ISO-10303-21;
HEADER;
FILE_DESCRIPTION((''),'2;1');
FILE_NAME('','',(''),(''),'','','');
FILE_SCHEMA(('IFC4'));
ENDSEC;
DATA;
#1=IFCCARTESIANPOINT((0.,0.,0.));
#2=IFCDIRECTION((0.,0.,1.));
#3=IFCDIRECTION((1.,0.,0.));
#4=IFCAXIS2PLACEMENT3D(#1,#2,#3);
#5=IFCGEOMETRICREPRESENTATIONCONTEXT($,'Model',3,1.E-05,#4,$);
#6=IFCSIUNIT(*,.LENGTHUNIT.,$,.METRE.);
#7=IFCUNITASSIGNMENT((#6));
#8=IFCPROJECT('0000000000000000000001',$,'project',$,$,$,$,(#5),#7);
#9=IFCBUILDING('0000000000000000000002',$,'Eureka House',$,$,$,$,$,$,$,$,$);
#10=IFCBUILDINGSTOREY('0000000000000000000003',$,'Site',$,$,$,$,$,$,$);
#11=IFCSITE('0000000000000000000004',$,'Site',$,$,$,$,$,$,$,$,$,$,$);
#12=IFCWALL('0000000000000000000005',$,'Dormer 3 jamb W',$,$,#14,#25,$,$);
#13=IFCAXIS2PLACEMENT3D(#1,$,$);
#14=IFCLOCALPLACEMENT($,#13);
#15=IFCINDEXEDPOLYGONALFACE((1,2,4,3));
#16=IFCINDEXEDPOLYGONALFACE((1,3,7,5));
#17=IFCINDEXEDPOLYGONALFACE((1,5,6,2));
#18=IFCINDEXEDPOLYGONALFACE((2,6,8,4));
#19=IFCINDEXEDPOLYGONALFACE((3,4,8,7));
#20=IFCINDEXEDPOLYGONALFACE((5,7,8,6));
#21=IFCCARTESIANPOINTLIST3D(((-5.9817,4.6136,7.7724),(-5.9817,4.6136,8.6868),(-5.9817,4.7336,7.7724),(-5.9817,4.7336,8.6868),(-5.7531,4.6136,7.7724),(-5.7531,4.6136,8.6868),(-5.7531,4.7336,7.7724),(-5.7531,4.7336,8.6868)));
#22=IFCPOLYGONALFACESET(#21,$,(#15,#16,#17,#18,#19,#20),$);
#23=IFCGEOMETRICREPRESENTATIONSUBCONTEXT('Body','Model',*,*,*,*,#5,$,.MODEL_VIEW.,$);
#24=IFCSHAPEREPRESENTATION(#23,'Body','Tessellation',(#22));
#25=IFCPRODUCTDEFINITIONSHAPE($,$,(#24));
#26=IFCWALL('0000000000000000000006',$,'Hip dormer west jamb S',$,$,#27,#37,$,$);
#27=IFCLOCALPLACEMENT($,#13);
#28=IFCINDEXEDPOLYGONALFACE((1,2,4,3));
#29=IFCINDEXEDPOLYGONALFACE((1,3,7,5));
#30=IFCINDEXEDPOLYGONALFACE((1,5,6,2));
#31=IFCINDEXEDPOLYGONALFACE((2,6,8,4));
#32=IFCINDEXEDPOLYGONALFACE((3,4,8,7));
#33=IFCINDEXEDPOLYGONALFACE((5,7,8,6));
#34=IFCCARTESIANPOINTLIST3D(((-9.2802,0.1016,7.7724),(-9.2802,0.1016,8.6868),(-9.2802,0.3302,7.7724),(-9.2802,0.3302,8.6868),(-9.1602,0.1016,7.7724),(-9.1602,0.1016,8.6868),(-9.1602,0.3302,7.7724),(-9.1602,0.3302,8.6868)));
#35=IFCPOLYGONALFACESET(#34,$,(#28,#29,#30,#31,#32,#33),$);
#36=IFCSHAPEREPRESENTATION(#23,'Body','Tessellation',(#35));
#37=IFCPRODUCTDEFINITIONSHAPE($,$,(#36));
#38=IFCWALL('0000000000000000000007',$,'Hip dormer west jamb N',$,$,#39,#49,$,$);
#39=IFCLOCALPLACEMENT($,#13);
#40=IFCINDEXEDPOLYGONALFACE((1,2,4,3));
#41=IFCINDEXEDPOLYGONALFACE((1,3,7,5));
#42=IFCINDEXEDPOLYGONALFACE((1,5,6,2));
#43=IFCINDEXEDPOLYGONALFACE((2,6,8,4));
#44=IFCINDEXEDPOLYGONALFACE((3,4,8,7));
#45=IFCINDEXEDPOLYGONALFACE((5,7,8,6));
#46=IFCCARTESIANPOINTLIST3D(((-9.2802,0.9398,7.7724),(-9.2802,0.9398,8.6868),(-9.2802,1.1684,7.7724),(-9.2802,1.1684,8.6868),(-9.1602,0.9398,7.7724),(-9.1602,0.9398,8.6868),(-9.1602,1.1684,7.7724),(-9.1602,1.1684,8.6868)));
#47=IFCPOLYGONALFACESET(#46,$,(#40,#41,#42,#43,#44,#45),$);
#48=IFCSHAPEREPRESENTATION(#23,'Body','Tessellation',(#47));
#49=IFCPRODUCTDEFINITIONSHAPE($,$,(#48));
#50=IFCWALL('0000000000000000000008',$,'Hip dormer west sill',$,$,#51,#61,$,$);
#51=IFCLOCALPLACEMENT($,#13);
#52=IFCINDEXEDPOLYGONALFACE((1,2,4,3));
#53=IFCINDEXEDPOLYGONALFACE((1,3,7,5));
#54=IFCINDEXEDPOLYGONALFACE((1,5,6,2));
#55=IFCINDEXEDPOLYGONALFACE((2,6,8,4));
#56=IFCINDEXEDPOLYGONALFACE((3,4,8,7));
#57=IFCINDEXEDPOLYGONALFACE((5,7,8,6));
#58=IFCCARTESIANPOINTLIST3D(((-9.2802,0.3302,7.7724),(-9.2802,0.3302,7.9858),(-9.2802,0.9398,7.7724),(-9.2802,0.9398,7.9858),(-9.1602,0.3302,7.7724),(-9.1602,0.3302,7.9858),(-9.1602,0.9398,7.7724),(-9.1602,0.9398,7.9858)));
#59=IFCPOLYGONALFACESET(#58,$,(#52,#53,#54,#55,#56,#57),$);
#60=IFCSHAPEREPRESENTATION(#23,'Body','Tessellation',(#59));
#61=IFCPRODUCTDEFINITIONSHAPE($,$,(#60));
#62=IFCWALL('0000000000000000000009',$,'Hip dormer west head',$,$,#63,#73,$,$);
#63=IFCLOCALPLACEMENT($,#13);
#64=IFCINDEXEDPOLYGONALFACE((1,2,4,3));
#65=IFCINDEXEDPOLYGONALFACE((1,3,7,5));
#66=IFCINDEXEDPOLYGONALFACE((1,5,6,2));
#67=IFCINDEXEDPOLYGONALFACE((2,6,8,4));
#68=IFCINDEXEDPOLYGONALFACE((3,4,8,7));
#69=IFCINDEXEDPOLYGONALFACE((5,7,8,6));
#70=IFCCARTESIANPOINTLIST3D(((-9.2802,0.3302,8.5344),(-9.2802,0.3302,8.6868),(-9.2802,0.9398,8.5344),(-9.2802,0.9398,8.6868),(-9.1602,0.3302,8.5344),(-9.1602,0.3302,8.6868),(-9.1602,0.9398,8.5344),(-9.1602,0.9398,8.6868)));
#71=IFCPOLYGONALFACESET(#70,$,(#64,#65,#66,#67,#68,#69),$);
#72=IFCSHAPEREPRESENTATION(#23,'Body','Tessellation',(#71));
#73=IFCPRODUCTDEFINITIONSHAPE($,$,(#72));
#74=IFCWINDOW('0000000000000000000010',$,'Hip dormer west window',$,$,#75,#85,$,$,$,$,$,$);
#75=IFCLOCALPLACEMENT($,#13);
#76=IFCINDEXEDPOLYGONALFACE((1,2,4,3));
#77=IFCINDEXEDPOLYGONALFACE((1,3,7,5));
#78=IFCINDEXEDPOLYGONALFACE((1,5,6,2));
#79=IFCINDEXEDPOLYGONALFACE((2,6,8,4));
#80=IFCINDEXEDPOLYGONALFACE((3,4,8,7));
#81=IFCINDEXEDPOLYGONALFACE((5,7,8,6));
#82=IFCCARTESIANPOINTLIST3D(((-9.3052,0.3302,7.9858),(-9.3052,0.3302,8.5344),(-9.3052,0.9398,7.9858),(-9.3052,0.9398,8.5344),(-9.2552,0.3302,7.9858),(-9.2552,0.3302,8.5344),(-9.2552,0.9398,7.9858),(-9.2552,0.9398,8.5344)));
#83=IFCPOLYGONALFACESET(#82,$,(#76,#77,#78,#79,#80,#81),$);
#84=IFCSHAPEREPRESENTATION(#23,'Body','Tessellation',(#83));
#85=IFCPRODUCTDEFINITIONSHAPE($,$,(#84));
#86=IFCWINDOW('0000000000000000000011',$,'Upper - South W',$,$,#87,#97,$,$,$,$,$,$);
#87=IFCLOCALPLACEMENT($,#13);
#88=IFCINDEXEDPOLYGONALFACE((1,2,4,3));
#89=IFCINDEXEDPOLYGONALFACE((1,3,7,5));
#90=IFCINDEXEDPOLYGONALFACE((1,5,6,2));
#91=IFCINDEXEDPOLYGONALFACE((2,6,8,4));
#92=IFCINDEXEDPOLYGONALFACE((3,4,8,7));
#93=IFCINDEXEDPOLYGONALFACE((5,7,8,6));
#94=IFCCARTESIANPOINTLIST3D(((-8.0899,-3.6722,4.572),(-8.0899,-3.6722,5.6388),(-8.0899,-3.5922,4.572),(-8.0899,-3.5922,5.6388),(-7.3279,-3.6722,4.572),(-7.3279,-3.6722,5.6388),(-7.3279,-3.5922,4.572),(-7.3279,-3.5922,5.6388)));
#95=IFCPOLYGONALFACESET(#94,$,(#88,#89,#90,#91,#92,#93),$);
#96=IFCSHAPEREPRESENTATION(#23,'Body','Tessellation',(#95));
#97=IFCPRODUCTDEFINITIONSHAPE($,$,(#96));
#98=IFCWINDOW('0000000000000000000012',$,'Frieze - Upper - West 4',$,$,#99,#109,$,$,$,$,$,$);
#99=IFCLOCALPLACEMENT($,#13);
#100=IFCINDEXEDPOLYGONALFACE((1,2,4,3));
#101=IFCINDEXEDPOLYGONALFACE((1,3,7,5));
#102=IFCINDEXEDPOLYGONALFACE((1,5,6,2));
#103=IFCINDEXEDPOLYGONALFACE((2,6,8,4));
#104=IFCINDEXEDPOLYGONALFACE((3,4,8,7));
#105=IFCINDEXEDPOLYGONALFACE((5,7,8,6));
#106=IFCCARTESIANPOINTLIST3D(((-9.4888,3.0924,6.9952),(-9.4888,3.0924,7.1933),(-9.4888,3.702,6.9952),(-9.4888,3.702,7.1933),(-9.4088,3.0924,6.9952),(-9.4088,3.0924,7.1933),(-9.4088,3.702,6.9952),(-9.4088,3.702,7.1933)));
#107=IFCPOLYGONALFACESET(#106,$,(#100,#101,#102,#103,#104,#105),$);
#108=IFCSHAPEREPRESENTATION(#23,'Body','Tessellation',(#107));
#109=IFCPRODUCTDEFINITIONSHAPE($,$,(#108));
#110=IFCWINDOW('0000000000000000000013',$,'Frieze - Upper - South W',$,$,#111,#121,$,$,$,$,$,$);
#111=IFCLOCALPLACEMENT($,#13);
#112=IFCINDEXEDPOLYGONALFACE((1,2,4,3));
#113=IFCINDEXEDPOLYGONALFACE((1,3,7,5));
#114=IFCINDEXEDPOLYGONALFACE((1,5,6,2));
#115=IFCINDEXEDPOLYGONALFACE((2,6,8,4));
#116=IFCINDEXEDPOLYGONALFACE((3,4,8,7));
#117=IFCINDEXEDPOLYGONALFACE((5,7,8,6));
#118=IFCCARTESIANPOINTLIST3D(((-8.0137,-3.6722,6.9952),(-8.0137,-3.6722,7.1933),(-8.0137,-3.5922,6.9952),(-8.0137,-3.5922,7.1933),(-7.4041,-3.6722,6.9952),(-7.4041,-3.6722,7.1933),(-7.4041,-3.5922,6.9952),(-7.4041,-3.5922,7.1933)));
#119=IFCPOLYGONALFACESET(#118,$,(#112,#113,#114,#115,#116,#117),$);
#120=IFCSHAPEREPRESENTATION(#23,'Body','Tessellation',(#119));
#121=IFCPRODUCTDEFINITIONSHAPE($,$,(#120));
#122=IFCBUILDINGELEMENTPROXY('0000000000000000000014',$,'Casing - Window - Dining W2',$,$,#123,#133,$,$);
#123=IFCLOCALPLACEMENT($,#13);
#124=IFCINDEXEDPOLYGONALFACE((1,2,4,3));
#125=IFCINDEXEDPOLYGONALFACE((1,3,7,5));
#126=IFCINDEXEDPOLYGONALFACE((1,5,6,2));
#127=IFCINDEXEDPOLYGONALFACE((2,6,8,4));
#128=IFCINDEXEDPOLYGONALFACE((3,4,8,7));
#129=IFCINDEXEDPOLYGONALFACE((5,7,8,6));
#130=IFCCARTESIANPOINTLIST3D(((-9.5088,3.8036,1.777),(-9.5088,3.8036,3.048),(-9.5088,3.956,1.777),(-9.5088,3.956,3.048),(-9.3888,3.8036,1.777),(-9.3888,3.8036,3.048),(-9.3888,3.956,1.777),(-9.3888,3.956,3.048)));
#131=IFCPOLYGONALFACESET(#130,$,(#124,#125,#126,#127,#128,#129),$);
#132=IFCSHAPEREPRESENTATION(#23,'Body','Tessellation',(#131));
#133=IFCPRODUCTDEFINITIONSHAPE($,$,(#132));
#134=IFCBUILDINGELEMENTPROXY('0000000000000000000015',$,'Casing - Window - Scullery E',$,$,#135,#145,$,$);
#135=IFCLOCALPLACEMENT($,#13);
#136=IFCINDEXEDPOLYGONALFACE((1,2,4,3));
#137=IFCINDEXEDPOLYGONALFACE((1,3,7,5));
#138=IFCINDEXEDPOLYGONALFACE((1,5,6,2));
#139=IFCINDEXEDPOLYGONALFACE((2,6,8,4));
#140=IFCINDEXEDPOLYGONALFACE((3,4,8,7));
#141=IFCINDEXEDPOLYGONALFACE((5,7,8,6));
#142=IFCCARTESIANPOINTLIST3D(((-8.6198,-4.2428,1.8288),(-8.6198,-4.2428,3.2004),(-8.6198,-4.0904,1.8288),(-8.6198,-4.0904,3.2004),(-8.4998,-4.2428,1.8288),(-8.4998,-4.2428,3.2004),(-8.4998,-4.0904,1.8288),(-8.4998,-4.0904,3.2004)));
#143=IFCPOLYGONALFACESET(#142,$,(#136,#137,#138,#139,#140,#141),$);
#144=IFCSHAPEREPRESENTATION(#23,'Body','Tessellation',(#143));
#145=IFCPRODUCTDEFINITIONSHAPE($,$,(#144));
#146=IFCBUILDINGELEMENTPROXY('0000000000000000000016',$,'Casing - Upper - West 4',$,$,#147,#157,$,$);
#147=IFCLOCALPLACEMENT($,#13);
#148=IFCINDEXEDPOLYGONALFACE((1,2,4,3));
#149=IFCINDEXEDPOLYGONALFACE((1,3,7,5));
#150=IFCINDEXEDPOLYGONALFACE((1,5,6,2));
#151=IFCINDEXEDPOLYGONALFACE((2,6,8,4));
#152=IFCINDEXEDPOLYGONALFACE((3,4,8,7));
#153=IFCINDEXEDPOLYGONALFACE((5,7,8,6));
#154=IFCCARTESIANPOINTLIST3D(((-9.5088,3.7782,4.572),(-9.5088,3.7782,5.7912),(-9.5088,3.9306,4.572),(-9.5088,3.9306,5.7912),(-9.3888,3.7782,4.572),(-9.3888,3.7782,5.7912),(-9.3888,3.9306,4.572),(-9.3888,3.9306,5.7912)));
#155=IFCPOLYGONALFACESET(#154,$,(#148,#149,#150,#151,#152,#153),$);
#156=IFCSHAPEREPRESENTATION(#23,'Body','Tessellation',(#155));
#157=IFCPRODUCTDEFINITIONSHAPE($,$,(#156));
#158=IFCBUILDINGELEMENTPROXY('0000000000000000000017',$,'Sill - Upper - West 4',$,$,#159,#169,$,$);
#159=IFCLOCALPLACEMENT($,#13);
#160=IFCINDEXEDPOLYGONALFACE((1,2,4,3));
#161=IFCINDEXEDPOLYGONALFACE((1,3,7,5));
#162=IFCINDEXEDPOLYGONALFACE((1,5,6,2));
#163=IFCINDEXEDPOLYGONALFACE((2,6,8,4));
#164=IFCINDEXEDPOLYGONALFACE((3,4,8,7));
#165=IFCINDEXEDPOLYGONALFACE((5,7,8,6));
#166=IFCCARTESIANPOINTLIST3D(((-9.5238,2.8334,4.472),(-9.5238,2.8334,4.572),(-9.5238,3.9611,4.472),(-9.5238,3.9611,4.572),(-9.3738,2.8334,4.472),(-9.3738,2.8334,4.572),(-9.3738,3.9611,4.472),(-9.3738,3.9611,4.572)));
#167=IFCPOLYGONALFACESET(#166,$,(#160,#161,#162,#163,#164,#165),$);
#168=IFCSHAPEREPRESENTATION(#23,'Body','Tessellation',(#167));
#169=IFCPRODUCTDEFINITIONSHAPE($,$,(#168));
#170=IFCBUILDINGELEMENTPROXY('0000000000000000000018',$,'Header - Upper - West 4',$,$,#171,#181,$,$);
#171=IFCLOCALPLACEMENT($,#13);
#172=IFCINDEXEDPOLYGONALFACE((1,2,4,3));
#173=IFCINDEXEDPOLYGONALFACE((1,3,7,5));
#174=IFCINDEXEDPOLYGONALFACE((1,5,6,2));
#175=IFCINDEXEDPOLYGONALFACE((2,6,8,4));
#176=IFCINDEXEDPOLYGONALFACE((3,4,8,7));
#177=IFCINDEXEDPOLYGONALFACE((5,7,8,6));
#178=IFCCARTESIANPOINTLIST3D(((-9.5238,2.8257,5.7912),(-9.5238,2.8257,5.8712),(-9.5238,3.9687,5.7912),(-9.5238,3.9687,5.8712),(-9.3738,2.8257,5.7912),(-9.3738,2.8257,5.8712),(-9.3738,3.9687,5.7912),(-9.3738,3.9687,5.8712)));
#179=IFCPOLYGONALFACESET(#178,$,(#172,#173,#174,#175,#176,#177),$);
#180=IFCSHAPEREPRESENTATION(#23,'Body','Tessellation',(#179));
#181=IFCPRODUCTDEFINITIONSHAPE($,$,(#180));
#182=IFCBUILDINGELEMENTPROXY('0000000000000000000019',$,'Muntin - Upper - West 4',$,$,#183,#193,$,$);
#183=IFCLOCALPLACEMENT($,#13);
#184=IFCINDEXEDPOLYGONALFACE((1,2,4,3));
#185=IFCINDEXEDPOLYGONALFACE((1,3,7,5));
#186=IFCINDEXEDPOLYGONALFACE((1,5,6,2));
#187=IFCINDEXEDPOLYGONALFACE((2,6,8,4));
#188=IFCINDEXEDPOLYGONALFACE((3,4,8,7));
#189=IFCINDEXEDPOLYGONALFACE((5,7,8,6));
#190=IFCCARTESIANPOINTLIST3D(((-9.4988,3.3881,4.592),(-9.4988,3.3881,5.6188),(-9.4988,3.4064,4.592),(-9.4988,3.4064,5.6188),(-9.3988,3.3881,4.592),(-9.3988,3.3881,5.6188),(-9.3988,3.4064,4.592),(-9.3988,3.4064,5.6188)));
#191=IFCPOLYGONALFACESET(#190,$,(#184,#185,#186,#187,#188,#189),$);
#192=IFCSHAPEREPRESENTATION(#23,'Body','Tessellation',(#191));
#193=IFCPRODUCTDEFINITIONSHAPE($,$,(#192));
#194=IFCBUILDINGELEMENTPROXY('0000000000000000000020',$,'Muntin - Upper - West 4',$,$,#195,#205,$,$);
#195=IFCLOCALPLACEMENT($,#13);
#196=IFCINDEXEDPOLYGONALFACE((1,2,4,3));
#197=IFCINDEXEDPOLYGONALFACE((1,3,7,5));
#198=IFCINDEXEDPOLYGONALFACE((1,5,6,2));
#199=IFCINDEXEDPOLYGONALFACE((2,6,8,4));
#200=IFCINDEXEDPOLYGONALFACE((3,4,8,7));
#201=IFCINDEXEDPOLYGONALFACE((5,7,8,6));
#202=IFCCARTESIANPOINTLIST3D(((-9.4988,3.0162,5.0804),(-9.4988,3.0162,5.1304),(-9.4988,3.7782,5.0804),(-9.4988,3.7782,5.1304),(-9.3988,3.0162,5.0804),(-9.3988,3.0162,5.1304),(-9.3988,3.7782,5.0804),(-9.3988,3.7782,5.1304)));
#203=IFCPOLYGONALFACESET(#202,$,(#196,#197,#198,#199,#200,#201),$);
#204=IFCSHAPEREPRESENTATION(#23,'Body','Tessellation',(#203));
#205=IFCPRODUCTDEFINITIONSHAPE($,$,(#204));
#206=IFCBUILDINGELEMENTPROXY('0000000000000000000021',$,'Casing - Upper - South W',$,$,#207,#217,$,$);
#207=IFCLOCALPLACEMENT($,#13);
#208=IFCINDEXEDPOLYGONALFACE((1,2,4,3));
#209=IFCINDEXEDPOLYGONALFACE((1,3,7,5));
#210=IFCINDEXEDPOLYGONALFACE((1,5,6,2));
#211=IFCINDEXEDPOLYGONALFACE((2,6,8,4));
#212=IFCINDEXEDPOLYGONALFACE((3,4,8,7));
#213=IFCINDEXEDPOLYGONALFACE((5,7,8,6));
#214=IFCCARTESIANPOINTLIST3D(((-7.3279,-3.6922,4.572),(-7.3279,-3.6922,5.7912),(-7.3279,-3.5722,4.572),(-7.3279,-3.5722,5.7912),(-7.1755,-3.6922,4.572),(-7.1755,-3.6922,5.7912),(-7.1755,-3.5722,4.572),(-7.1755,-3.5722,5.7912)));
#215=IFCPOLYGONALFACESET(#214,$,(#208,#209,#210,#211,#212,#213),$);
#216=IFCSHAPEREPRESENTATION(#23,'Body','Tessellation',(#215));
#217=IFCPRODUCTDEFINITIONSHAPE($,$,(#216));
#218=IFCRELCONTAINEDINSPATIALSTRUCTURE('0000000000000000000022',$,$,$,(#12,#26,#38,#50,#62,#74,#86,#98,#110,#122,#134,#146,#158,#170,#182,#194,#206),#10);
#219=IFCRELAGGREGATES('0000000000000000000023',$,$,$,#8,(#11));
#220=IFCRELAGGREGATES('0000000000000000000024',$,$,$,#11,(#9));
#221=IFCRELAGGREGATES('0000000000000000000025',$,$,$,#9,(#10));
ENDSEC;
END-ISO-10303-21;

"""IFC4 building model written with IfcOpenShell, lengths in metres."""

from ifc_helpers import new_model, si_unit, frame, origin, origin_with_axes, origin_2d, place, context, subcontext, project, spatial, rectangle, extrude, element, save


model = new_model("IFC4")

# Units and contexts
model_context = context("Model", 3, precision=1e-05, world=origin_with_axes())
body_context = subcontext(model_context, "Body", "Model", "MODEL_VIEW")
ifc_project = project(units=[si_unit("LENGTHUNIT", "METRE")], contexts=[model_context])

# Site, building, storey
site = spatial("IfcSite", under=ifc_project, Name="Site")
building = spatial("IfcBuilding", under=site, Name="Eureka House")
storey = spatial("IfcBuildingStorey", under=building, Name="Site")

# Walls
wall_1_placement = place(None, frame((-5.8674, 4.6736, 7.7724), z_axis=(0.0, 0.0, 1.0), x_axis=(1.0, 0.0, 0.0)))
element("IfcWall", 1, at=wall_1_placement, inside=storey, Name="Dormer 3 jamb W", context=body_context, shape_type="SweptSolid", body=[
    extrude(rectangle(XDim=0.2286, YDim=0.12, at=origin_2d()), origin(), (0.0, 0.0, 1.0), 0.9144),
])
wall_2_placement = place(None, frame((-9.2202, 0.2159, 7.7724), z_axis=(0.0, 0.0, 1.0), x_axis=(1.0, 0.0, 0.0)))
element("IfcWall", 2, at=wall_2_placement, inside=storey, Name="Hip dormer west jamb S", context=body_context, shape_type="SweptSolid", body=[
    extrude(rectangle(XDim=0.12, YDim=0.2286, at=origin_2d()), origin(), (0.0, 0.0, 1.0), 0.9144),
])
wall_3_placement = place(None, frame((-9.2202, 1.0541, 7.7724), z_axis=(0.0, 0.0, 1.0), x_axis=(1.0, 0.0, 0.0)))
element("IfcWall", 3, at=wall_3_placement, inside=storey, Name="Hip dormer west jamb N", context=body_context, shape_type="SweptSolid", body=[
    extrude(rectangle(XDim=0.12, YDim=0.2286, at=origin_2d()), origin(), (0.0, 0.0, 1.0), 0.9144),
])
wall_4_placement = place(None, frame((-9.2202, 0.635, 7.7724), z_axis=(0.0, 0.0, 1.0), x_axis=(1.0, 0.0, 0.0)))
element("IfcWall", 4, at=wall_4_placement, inside=storey, Name="Hip dormer west sill", context=body_context, shape_type="SweptSolid", body=[
    extrude(rectangle(XDim=0.12, YDim=0.6096, at=origin_2d()), origin(), (0.0, 0.0, 1.0), 0.2134),
])
wall_5_placement = place(None, frame((-9.2202, 0.635, 8.5344), z_axis=(0.0, 0.0, 1.0), x_axis=(1.0, 0.0, 0.0)))
element("IfcWall", 5, at=wall_5_placement, inside=storey, Name="Hip dormer west head", context=body_context, shape_type="SweptSolid", body=[
    extrude(rectangle(XDim=0.12, YDim=0.6096, at=origin_2d()), origin(), (0.0, 0.0, 1.0), 0.1524),
])

# Windows
window_1_placement = place(None, frame((-9.2802, 0.635, 7.9858), z_axis=(0.0, 0.0, 1.0), x_axis=(1.0, 0.0, 0.0)))
element("IfcWindow", 6, at=window_1_placement, inside=storey, Name="Hip dormer west window", context=body_context, shape_type="SweptSolid", body=[
    extrude(rectangle(XDim=0.05, YDim=0.6096, at=origin_2d()), origin(), (0.0, 0.0, 1.0), 0.5486),
])
window_2_placement = place(None, frame((-7.7089, -3.6322, 4.572), z_axis=(0.0, 0.0, 1.0), x_axis=(1.0, 0.0, 0.0)))
element("IfcWindow", 7, at=window_2_placement, inside=storey, Name="Upper - South W", context=body_context, shape_type="SweptSolid", body=[
    extrude(rectangle(XDim=0.762, YDim=0.08, at=origin_2d()), origin(), (0.0, 0.0, 1.0), 1.0668),
])
window_3_placement = place(None, frame((-9.4488, 3.3972, 6.9952), z_axis=(0.0, 0.0, 1.0), x_axis=(1.0, 0.0, 0.0)))
element("IfcWindow", 8, at=window_3_placement, inside=storey, Name="Frieze - Upper - West 4", context=body_context, shape_type="SweptSolid", body=[
    extrude(rectangle(XDim=0.08, YDim=0.6096, at=origin_2d()), origin(), (0.0, 0.0, 1.0), 0.1981),
])
window_4_placement = place(None, frame((-7.7089, -3.6322, 6.9952), z_axis=(0.0, 0.0, 1.0), x_axis=(1.0, 0.0, 0.0)))
element("IfcWindow", 9, at=window_4_placement, inside=storey, Name="Frieze - Upper - South W", context=body_context, shape_type="SweptSolid", body=[
    extrude(rectangle(XDim=0.6096, YDim=0.08, at=origin_2d()), origin(), (0.0, 0.0, 1.0), 0.1981),
])

# Building element proxies
proxy_1_placement = place(None, frame((-9.4488, 3.8798, 1.777), z_axis=(0.0, 0.0, 1.0), x_axis=(1.0, 0.0, 0.0)))
element("IfcBuildingElementProxy", 10, at=proxy_1_placement, inside=storey, Name="Casing - Window - Dining W2", context=body_context, shape_type="SweptSolid", body=[
    extrude(rectangle(XDim=0.12, YDim=0.1524, at=origin_2d()), origin(), (0.0, 0.0, 1.0), 1.271),
])
proxy_2_placement = place(None, frame((-8.5598, -4.1666, 1.8288), z_axis=(0.0, 0.0, 1.0), x_axis=(1.0, 0.0, 0.0)))
element("IfcBuildingElementProxy", 11, at=proxy_2_placement, inside=storey, Name="Casing - Window - Scullery E", context=body_context, shape_type="SweptSolid", body=[
    extrude(rectangle(XDim=0.12, YDim=0.1524, at=origin_2d()), origin(), (0.0, 0.0, 1.0), 1.3716),
])
proxy_3_placement = place(None, frame((-9.4488, 3.8544, 4.572), z_axis=(0.0, 0.0, 1.0), x_axis=(1.0, 0.0, 0.0)))
element("IfcBuildingElementProxy", 12, at=proxy_3_placement, inside=storey, Name="Casing - Upper - West 4", context=body_context, shape_type="SweptSolid", body=[
    extrude(rectangle(XDim=0.12, YDim=0.1524, at=origin_2d()), origin(), (0.0, 0.0, 1.0), 1.2192),
])
proxy_4_placement = place(None, frame((-9.4488, 3.3972, 4.472), z_axis=(0.0, 0.0, 1.0), x_axis=(1.0, 0.0, 0.0)))
element("IfcBuildingElementProxy", 13, at=proxy_4_placement, inside=storey, Name="Sill - Upper - West 4", context=body_context, shape_type="SweptSolid", body=[
    extrude(rectangle(XDim=0.15, YDim=1.1278, at=origin_2d()), origin(), (0.0, 0.0, 1.0), 0.1),
])
proxy_5_placement = place(None, frame((-9.4488, 3.3972, 5.7912), z_axis=(0.0, 0.0, 1.0), x_axis=(1.0, 0.0, 0.0)))
element("IfcBuildingElementProxy", 14, at=proxy_5_placement, inside=storey, Name="Header - Upper - West 4", context=body_context, shape_type="SweptSolid", body=[
    extrude(rectangle(XDim=0.15, YDim=1.143, at=origin_2d()), origin(), (0.0, 0.0, 1.0), 0.08),
])
proxy_6_placement = place(None, frame((-9.4488, 3.3972, 4.592), z_axis=(0.0, 0.0, 1.0), x_axis=(1.0, 0.0, 0.0)))
element("IfcBuildingElementProxy", 15, at=proxy_6_placement, inside=storey, Name="Muntin - Upper - West 4", context=body_context, shape_type="SweptSolid", body=[
    extrude(rectangle(XDim=0.1, YDim=0.0183, at=origin_2d()), origin(), (0.0, 0.0, 1.0), 1.0268),
])
proxy_7_placement = place(None, frame((-9.4488, 3.3972, 5.0804), z_axis=(0.0, 0.0, 1.0), x_axis=(1.0, 0.0, 0.0)))
element("IfcBuildingElementProxy", 16, at=proxy_7_placement, inside=storey, Name="Muntin - Upper - West 4", context=body_context, shape_type="SweptSolid", body=[
    extrude(rectangle(XDim=0.1, YDim=0.762, at=origin_2d()), origin(), (0.0, 0.0, 1.0), 0.05),
])
for number, where, z_axis, x_axis, name in (
    (17, (-7.2517, -3.6322, 4.572), (0.0, 0.0, 1.0), (1.0, 0.0, 0.0), "Casing - Upper - South W"),
):
    element("IfcBuildingElementProxy", number, at=place(None, frame(where, z_axis=z_axis, x_axis=x_axis)), inside=storey, Name=name, context=body_context, shape_type="SweptSolid", body=[
        extrude(rectangle(XDim=0.1524, YDim=0.12, at=origin_2d()), origin(), (0.0, 0.0, 1.0), 1.2192),
    ])

save(model, "model.ifc")
